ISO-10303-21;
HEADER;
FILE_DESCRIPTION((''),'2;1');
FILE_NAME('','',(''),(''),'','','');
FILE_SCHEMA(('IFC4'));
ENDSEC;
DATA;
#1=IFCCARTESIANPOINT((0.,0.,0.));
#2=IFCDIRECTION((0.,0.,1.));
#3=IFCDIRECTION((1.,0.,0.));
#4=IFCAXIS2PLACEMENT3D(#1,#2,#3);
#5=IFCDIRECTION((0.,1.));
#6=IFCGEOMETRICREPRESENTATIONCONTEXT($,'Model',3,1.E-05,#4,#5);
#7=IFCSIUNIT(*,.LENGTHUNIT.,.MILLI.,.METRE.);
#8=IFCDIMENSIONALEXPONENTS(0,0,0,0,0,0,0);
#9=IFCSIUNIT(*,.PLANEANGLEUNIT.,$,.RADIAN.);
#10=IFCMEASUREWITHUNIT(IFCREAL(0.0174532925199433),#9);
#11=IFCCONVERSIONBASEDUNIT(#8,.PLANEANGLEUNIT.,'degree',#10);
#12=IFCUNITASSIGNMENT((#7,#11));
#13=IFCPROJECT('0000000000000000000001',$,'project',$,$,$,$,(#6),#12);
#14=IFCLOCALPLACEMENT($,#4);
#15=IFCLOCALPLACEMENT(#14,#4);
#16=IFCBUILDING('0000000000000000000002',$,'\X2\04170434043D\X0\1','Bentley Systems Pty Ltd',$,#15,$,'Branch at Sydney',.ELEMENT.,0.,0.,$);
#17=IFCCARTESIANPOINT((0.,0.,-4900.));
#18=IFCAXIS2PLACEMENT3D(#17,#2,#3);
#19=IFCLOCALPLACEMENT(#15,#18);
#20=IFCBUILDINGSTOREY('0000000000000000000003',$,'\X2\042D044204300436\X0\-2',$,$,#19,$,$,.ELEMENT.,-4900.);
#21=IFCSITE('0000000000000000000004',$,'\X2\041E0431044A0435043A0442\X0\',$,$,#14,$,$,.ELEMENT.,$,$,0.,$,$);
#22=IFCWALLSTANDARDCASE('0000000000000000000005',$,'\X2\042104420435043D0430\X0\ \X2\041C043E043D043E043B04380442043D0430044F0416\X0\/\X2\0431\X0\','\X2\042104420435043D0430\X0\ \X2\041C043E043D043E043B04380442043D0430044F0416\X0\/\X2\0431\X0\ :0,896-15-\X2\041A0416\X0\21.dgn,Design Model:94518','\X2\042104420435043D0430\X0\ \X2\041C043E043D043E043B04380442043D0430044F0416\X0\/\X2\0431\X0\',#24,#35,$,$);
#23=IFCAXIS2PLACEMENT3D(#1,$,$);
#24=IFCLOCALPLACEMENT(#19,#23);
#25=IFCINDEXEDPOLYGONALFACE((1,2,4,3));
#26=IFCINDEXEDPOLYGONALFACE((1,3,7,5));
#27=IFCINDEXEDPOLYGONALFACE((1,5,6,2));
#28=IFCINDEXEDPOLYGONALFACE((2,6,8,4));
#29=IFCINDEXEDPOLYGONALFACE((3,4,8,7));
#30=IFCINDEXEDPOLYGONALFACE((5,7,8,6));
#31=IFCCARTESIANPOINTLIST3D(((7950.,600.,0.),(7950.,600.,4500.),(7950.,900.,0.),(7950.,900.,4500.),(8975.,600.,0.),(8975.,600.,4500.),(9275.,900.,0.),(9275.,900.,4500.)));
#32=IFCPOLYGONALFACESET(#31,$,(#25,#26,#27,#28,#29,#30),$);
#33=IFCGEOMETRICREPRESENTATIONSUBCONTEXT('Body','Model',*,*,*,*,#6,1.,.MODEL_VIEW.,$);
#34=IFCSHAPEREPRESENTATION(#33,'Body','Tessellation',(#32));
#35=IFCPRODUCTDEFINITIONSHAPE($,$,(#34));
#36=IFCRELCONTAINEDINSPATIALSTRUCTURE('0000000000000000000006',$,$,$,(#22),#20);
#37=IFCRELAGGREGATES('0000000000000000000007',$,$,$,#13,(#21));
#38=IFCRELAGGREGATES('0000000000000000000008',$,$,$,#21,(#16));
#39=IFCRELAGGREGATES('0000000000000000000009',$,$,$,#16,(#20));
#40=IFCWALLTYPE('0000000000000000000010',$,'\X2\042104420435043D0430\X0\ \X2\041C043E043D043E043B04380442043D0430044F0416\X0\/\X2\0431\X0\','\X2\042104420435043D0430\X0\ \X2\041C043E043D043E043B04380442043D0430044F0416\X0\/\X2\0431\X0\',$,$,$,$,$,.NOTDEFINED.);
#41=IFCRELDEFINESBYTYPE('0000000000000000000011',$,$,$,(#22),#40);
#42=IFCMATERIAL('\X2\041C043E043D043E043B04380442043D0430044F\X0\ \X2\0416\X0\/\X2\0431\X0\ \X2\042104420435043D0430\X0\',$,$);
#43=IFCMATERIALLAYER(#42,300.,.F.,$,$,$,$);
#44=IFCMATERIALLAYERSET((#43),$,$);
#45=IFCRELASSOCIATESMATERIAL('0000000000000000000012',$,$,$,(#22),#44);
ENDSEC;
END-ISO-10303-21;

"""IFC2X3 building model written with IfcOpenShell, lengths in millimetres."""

from ifc_helpers import new_model, entity, si_unit, converted_unit, direction, frame, origin_with_axes, place, context, subcontext, project, spatial, polyline, outline, extrude, material, layer, layer_set, layer_usage, type_object, element, save


model = new_model("IFC2X3")

# Units and contexts
model_context = context("Model", 3, precision=1e-05, world=origin_with_axes(), true_north=direction((0.0, 1.0)))
body_context = subcontext(model_context, "Body", "Model", "MODEL_VIEW", scale=1.0)
ifc_project = project(units=[si_unit("LENGTHUNIT", "METRE", prefix="MILLI"), converted_unit("PLANEANGLEUNIT", "degree", entity("IfcReal", 0.0174532925199433), si_unit("PLANEANGLEUNIT", "RADIAN"), dimensions=[0, 0, 0, 0, 0, 0, 0])], contexts=[model_context])

# Site, building, storey
site_placement = place(None, origin_with_axes())
site = spatial("IfcSite", under=ifc_project, at=site_placement, Name="Объект", CompositionType="ELEMENT", RefElevation=0.0)
building_placement = place(site_placement, origin_with_axes())
building = spatial("IfcBuilding", under=site, at=building_placement, Name="Здн1", Description="Bentley Systems Pty Ltd", LongName="Branch at Sydney", CompositionType="ELEMENT", ElevationOfRefHeight=0.0, ElevationOfTerrain=0.0)
storey_placement = place(building_placement, frame((0.0, 0.0, -4900.0), z_axis=(0.0, 0.0, 1.0), x_axis=(1.0, 0.0, 0.0)))
storey = spatial("IfcBuildingStorey", under=building, at=storey_placement, Name="Этаж-2", CompositionType="ELEMENT", Elevation=-4900.0)

# Wall
ifc_material = material(Name="Монолитная Ж/б Стена")
ifc_layer = layer(ifc_material, 300.0, ventilated=False)
ifc_layer_set = layer_set([ifc_layer])
ifc_layer_usage = layer_usage(ifc_layer_set, "AXIS2", "POSITIVE", 0.0)
wall_type = type_object("IfcWallType", Name="Стена МонолитнаяЖ/б", Description="Стена МонолитнаяЖ/б", PredefinedType="NOTDEFINED")
wall_placement = place(storey_placement, frame((7950.0, 600.0, 0.0), z_axis=(0.0, 0.0, 1.0), x_axis=(1.0, 0.0, 0.0)))
element("IfcWallStandardCase", 1, at=wall_placement, inside=storey, type_object=wall_type, material=ifc_layer_usage, Name="Стена МонолитнаяЖ/б", Description="Стена МонолитнаяЖ/б :0,896-15-КЖ21.dgn,Design Model:94518", ObjectType="Стена МонолитнаяЖ/б", context=body_context, shape_type="SweptSolid", body=[
    extrude(outline(polyline([(1325.0, 300.0), (0.0, 300.0), (0.0, 0.0), (1025.0, 0.0), (1325.0, 300.0)])), origin_with_axes(), (0.0, 0.0, 1.0), 4500.0),
])

save(model, "model.ifc")
